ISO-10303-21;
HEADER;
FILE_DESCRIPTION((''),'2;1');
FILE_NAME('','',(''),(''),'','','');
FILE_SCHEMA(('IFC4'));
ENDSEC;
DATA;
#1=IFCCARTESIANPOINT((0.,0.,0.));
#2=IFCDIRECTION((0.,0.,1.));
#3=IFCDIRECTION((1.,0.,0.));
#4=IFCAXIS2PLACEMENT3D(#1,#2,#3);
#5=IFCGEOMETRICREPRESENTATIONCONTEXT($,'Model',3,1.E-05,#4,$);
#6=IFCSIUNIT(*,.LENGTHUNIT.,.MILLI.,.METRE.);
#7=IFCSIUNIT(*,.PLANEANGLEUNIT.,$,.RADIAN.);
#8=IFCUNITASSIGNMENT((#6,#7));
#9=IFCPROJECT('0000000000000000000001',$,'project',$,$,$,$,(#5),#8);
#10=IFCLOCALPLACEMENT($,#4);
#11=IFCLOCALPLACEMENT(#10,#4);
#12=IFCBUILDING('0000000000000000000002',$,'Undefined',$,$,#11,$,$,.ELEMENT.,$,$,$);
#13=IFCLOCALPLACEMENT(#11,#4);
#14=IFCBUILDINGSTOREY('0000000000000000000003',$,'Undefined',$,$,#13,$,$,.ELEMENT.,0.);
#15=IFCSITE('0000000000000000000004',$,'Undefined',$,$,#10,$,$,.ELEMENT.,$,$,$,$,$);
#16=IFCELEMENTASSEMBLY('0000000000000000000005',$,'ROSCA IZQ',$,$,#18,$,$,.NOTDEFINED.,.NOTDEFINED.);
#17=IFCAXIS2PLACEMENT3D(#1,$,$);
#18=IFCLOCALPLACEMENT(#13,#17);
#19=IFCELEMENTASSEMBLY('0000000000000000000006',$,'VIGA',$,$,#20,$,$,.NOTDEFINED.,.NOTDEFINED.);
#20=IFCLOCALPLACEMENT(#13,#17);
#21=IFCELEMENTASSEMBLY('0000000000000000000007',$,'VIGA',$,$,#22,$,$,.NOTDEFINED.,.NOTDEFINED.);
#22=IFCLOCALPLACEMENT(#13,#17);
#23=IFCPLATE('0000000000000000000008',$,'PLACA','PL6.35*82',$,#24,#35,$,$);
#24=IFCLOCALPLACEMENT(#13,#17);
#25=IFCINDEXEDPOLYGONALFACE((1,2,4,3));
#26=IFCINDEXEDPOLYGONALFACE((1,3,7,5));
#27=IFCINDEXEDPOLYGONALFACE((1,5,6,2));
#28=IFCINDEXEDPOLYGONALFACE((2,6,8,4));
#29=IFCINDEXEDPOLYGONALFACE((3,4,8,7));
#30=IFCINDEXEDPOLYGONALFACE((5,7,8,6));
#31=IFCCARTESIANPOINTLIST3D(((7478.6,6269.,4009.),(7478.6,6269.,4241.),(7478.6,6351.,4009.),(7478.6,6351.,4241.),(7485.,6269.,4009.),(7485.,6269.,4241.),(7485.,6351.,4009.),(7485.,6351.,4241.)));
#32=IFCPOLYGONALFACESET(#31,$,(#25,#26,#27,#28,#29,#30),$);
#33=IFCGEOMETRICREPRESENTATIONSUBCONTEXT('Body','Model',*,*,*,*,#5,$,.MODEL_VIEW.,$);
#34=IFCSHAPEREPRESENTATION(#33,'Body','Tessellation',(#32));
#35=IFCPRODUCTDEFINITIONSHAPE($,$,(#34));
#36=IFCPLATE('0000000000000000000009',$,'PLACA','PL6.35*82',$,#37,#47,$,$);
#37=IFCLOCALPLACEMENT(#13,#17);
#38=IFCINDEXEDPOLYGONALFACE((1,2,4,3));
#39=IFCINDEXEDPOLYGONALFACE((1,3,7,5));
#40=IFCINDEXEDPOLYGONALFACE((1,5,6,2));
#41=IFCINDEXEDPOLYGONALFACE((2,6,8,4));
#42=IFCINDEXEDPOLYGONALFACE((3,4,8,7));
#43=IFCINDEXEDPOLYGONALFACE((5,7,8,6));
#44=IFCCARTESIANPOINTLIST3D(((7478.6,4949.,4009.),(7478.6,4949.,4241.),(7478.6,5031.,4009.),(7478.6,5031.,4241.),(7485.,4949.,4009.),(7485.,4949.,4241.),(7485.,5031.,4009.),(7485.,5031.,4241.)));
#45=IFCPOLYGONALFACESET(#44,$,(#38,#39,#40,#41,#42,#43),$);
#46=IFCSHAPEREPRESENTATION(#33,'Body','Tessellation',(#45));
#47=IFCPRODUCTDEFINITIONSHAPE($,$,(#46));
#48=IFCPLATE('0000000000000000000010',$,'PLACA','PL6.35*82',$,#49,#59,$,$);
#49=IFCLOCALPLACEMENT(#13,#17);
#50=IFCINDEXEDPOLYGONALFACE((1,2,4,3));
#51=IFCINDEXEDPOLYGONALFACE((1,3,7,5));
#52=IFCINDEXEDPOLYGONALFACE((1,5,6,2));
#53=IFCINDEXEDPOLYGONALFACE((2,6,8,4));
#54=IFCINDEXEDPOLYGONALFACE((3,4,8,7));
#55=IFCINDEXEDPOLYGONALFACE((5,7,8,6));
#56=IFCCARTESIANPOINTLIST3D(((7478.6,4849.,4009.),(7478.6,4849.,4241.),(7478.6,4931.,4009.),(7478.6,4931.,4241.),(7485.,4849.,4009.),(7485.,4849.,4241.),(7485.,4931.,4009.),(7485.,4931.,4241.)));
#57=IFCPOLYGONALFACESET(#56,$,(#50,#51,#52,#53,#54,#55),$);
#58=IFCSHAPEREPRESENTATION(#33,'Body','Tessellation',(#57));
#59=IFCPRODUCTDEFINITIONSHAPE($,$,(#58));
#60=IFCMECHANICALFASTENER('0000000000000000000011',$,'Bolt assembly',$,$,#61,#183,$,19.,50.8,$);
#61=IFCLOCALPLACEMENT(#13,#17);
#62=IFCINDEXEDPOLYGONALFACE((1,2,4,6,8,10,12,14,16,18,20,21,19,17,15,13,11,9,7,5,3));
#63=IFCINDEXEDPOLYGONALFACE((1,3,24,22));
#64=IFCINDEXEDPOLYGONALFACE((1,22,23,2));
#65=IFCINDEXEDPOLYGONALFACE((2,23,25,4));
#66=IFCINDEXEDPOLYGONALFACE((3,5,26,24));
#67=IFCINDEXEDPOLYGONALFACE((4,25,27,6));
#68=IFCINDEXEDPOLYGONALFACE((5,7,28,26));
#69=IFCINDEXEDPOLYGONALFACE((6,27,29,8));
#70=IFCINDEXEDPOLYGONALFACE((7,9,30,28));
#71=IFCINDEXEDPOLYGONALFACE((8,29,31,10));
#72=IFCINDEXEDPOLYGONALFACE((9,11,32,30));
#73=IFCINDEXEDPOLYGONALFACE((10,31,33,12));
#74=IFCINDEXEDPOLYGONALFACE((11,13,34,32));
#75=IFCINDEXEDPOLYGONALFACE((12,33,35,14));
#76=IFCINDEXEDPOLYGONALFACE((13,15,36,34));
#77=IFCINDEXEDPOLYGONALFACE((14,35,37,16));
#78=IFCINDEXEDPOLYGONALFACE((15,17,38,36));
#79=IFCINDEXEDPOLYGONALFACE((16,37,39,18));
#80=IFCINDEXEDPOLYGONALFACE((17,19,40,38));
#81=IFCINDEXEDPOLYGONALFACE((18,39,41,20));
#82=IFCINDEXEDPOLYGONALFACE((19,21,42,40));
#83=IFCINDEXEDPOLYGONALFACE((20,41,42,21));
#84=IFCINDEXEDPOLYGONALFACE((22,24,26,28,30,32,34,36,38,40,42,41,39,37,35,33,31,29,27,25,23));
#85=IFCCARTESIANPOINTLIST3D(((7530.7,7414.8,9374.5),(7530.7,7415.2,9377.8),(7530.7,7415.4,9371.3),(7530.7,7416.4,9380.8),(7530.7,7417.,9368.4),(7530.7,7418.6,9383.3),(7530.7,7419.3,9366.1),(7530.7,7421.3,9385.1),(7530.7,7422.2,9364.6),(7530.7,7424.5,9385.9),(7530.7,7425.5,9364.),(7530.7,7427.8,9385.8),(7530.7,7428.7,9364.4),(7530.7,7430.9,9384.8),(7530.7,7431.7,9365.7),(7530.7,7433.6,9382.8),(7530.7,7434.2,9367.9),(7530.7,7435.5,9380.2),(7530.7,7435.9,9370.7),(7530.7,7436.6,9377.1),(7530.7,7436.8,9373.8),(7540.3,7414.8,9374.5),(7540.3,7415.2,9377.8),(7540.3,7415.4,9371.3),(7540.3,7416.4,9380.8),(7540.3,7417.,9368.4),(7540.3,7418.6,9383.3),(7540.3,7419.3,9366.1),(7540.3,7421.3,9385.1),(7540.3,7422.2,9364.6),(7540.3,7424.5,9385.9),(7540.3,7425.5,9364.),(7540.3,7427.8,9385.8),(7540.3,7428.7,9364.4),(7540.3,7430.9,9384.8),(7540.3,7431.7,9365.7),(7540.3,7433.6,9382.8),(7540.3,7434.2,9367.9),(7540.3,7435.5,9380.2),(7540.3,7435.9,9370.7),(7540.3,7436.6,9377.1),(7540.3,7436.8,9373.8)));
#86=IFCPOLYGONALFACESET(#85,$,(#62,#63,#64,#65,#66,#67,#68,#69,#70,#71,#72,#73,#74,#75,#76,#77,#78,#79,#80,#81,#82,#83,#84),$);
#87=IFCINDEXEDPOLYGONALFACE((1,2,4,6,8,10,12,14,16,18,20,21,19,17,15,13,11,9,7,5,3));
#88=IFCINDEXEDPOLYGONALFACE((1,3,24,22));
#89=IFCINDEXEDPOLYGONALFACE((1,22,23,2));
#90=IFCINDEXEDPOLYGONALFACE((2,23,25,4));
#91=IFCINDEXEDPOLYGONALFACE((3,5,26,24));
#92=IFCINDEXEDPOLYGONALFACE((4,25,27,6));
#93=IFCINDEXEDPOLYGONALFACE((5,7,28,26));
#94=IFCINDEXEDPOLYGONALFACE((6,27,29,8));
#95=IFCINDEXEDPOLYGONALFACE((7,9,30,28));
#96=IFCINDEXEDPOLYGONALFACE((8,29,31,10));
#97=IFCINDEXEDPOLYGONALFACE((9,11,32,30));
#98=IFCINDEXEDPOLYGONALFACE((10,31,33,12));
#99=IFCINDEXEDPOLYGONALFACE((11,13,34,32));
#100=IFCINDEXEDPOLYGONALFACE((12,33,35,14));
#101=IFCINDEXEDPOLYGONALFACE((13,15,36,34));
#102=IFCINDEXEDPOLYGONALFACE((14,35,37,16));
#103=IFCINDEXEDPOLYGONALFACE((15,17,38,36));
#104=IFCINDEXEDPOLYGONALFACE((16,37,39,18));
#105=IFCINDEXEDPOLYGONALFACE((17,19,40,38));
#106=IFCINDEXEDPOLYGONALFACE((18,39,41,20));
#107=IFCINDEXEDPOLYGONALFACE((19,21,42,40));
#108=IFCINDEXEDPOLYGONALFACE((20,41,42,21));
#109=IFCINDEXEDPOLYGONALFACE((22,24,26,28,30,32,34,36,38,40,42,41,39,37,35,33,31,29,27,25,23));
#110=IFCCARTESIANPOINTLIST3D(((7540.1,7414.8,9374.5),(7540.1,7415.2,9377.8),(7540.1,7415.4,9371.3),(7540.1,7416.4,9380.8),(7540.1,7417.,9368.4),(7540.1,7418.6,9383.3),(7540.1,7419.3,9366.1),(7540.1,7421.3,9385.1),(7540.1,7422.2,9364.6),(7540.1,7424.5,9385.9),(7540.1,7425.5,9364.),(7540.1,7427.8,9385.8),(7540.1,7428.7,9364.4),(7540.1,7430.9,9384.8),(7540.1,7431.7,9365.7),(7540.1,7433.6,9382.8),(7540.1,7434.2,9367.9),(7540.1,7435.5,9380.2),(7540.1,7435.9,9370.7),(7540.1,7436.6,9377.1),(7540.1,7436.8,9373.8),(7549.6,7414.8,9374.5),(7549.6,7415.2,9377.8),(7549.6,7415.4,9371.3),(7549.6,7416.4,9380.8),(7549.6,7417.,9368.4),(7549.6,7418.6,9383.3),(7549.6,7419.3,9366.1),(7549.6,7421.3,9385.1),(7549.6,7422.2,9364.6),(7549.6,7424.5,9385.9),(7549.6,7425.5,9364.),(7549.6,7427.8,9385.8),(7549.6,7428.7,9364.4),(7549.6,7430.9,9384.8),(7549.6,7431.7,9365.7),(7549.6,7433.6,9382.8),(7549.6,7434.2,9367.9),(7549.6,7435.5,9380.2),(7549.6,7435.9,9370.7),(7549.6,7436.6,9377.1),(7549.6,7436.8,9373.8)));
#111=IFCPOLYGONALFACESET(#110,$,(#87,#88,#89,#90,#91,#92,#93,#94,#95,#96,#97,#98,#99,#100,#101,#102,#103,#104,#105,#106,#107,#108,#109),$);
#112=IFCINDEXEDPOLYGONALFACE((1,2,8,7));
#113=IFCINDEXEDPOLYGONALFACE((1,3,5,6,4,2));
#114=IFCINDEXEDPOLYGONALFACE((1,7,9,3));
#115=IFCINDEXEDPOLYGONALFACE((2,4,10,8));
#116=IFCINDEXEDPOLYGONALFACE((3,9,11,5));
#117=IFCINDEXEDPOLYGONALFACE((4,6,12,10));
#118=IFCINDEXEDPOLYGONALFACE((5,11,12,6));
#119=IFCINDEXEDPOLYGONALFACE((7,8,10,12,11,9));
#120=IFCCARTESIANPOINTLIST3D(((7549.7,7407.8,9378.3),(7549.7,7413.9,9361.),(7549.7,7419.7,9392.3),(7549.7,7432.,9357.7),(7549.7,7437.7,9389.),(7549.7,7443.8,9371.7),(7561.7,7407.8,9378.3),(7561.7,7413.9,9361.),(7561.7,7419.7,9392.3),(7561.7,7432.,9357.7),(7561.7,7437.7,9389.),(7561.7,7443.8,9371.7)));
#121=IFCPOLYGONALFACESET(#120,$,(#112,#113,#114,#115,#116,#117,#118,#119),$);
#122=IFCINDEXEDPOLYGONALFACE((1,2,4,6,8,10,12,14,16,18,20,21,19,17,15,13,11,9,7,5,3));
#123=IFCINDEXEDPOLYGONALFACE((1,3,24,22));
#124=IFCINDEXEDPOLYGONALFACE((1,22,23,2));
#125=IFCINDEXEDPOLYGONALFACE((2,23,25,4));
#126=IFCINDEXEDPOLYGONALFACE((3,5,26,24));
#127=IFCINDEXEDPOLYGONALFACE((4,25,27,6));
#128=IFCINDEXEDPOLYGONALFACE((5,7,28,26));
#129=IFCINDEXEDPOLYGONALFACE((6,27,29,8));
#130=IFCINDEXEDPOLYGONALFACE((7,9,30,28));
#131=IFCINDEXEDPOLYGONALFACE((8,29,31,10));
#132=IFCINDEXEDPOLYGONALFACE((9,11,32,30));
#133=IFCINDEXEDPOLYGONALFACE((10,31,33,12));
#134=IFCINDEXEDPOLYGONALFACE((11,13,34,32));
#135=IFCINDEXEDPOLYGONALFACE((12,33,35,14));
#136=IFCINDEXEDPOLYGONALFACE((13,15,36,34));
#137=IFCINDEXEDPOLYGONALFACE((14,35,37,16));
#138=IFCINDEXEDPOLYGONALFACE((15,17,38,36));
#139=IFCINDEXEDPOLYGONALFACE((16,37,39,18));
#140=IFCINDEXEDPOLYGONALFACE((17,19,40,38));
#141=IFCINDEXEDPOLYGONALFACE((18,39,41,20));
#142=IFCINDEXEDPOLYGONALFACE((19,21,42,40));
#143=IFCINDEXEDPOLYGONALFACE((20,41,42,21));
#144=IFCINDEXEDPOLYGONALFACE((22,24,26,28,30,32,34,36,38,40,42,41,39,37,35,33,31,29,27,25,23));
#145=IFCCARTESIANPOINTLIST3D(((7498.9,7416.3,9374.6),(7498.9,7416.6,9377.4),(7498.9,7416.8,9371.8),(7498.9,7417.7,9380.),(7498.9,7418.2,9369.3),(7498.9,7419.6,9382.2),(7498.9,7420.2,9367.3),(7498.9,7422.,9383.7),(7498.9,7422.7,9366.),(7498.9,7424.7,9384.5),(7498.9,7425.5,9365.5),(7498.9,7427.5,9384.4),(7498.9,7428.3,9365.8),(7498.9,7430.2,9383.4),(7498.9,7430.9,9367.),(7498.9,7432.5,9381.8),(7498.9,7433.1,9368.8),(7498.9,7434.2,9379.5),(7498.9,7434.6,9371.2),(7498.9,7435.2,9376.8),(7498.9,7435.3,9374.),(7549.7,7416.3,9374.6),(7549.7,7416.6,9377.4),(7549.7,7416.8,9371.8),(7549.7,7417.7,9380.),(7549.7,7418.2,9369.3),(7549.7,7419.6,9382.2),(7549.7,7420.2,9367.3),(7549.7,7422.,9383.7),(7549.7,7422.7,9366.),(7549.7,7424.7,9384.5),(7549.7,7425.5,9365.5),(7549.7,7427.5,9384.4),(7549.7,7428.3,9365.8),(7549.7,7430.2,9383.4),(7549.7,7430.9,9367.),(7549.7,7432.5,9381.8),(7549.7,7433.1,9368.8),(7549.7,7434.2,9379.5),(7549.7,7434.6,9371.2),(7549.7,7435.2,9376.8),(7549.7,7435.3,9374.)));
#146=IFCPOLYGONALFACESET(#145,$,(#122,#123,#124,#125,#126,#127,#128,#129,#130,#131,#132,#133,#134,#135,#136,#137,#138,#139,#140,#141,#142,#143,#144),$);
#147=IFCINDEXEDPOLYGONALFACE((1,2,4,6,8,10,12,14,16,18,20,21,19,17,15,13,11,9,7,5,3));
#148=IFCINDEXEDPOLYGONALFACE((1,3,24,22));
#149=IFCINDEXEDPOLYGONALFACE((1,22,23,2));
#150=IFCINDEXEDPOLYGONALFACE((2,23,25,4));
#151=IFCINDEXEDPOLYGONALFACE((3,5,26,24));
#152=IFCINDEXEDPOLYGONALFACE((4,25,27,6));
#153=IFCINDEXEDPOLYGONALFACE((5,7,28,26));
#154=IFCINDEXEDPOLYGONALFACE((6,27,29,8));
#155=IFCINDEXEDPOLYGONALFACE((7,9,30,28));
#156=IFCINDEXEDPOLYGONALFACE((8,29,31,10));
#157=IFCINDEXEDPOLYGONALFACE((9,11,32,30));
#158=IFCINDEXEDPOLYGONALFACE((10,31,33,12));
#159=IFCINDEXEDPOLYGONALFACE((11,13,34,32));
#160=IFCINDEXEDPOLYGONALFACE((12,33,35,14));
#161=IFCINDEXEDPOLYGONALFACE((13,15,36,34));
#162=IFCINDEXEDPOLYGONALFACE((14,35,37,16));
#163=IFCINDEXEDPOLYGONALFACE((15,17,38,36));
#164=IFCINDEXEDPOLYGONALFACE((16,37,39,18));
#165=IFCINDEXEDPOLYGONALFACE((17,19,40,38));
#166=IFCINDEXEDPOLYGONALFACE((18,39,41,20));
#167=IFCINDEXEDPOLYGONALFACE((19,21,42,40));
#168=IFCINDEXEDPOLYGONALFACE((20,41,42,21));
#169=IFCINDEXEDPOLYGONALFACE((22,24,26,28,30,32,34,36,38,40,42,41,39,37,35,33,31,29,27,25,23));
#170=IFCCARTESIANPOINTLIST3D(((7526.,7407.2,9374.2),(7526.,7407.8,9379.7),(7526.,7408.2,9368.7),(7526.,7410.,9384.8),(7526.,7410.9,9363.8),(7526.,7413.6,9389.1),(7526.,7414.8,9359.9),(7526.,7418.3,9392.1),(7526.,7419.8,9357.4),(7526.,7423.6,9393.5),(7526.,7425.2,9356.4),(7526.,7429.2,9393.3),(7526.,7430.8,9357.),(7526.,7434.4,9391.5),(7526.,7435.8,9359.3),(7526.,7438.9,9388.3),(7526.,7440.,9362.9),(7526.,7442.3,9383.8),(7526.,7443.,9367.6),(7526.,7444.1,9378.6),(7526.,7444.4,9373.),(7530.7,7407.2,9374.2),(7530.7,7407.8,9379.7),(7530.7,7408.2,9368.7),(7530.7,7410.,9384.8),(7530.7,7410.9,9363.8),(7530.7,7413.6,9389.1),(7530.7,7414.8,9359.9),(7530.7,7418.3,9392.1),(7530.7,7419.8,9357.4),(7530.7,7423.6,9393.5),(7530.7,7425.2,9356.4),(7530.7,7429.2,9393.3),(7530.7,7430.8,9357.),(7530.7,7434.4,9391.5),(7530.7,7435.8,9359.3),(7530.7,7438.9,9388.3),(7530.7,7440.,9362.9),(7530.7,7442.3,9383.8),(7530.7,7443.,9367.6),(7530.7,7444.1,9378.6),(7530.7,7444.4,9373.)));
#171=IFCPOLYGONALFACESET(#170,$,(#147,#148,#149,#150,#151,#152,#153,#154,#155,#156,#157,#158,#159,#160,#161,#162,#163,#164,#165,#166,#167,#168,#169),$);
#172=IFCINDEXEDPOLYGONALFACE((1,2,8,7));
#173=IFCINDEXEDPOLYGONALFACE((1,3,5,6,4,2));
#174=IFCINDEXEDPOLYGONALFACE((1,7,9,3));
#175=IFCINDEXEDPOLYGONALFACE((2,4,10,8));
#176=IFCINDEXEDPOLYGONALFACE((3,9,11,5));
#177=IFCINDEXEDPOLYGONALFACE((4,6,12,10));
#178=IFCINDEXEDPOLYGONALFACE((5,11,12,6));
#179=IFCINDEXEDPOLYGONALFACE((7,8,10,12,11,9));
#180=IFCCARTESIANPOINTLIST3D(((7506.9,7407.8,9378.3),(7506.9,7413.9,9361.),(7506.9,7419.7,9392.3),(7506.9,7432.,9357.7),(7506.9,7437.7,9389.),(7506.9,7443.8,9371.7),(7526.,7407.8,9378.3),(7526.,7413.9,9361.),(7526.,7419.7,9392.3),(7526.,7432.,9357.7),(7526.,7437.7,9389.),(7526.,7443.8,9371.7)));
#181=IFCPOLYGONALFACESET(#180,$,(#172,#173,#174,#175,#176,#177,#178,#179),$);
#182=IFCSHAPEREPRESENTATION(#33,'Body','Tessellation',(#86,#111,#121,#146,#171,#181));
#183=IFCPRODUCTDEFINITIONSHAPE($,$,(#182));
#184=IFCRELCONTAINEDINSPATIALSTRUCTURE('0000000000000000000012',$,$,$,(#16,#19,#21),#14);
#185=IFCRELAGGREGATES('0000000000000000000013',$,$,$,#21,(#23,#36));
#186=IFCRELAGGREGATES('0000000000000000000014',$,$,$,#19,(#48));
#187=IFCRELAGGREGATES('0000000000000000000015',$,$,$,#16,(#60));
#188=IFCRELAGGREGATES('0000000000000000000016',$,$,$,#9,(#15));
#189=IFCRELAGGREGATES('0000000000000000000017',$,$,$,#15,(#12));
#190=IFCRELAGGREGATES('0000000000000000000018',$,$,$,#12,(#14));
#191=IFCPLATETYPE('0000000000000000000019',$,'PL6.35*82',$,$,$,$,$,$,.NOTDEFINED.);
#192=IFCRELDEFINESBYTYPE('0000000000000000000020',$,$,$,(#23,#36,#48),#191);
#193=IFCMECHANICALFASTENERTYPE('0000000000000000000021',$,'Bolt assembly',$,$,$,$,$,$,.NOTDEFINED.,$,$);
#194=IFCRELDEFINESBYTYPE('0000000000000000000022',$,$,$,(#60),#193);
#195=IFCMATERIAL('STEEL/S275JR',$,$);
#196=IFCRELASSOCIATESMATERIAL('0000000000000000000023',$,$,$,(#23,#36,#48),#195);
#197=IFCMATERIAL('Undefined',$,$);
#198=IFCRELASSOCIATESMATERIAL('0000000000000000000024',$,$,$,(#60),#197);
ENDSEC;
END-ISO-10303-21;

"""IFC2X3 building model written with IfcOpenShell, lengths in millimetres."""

from ifc_helpers import new_model, si_unit, frame, origin_with_axes, origin_2d_with_axis, place, context, subcontext, project, spatial, polyline, circle, outline, extrude, source, transform, mapped, material, type_object, element, aggregate, save


model = new_model("IFC2X3")

# Units and contexts
model_context = context("Model", 3, precision=1e-05, world=origin_with_axes())
body_context = subcontext(model_context, "Body", "Model", "MODEL_VIEW")
ifc_project = project(units=[si_unit("LENGTHUNIT", "METRE", prefix="MILLI"), si_unit("PLANEANGLEUNIT", "RADIAN")], contexts=[model_context])

# Site, building, storey
site_placement = place(None, origin_with_axes())
site = spatial("IfcSite", under=ifc_project, at=site_placement, Name="Undefined", CompositionType="ELEMENT")
building_placement = place(site_placement, origin_with_axes())
building = spatial("IfcBuilding", under=site, at=building_placement, Name="Undefined", CompositionType="ELEMENT")
storey_placement = place(building_placement, origin_with_axes())
storey = spatial("IfcBuildingStorey", under=building, at=storey_placement, Name="Undefined", CompositionType="ELEMENT", Elevation=0.0)

# Shared definitions
ifc_material_1 = material(Name="STEEL/S275JR")

# Element assembly
assembly_1_placement = place(storey_placement, origin_with_axes())
assembly_1 = element("IfcElementAssembly", 1, at=assembly_1_placement, inside=storey, Name="ROSCA IZQ", AssemblyPlace="NOTDEFINED", PredefinedType="NOTDEFINED")

# Element assembly
assembly_2_placement = place(storey_placement, origin_with_axes())
assembly_2 = element("IfcElementAssembly", 2, at=assembly_2_placement, inside=storey, Name="VIGA", AssemblyPlace="NOTDEFINED", PredefinedType="NOTDEFINED")

# Shared definitions
plate_type_1 = type_object("IfcPlateType", Name="PL6.35*82", PredefinedType="NOTDEFINED")

# Element assembly, plates
assembly_3_placement = place(storey_placement, origin_with_axes())
assembly_3 = element("IfcElementAssembly", 3, at=assembly_3_placement, inside=storey, Name="VIGA", AssemblyPlace="NOTDEFINED", PredefinedType="NOTDEFINED")
plate_1_placement = place(assembly_3_placement, frame((7481.8, 6269.0, 4241.0), z_axis=(-1.0, 0.0, 0.0), x_axis=(0.0, 1.0, 0.0)))
plate_1 = element("IfcPlate", 4, at=plate_1_placement, type_object=plate_type_1, material=ifc_material_1, Name="PLACA", Description="PL6.35*82", context=body_context, shape_type="SweptSolid", body=[
    extrude(outline(polyline([(0.0, 0.0), (82.0, 0.0), (82.0, 232.0), (0.0, 232.0), (0.0, 0.0)])), frame((0.0, 0.0, -3.2), z_axis=(0.0, 0.0, 1.0), x_axis=(1.0, 0.0, 0.0)), (0.0, 0.0, 1.0), 6.4),
])
plate_2_placement = place(assembly_3_placement, frame((7481.8, 4949.0, 4241.0), z_axis=(-1.0, 0.0, 0.0), x_axis=(0.0, 1.0, 0.0)))
plate_2 = element("IfcPlate", 5, at=plate_2_placement, type_object=plate_type_1, material=ifc_material_1, Name="PLACA", Description="PL6.35*82", context=body_context, shape_type="SweptSolid", body=[
    extrude(outline(polyline([(0.0, 0.0), (82.0, 0.0), (82.0, 232.0), (0.0, 232.0), (0.0, 0.0)])), frame((0.0, 0.0, -3.2), z_axis=(0.0, 0.0, 1.0), x_axis=(1.0, 0.0, 0.0)), (0.0, 0.0, 1.0), 6.4),
])
aggregate(assembly_3, [plate_1, plate_2])

# Plate
plate_3_placement = place(assembly_2_placement, frame((7481.8, 4849.0, 4241.0), z_axis=(-1.0, 0.0, 0.0), x_axis=(0.0, 1.0, 0.0)))
plate_3 = element("IfcPlate", 6, at=plate_3_placement, type_object=plate_type_1, material=ifc_material_1, Name="PLACA", Description="PL6.35*82", context=body_context, shape_type="SweptSolid", body=[
    extrude(outline(polyline([(0.0, 0.0), (82.0, 0.0), (82.0, 232.0), (0.0, 232.0), (0.0, 0.0)])), frame((0.0, 0.0, -3.2), z_axis=(0.0, 0.0, 1.0), x_axis=(1.0, 0.0, 0.0)), (0.0, 0.0, 1.0), 6.4),
])
aggregate(assembly_2, [plate_3])

# Mechanical fastener
ifc_material_2 = material(Name="Undefined")
mechanical_fastener_type = type_object("IfcMechanicalFastenerType", Name="Bolt assembly")
shared_shape_1 = source(origin_with_axes(), body_context, "Body", "SweptSolid", [
    extrude(circle(Radius=11.0, at=origin_2d_with_axis()), frame((0.0, 4.6, 0.0), z_axis=(0.0, 1.0, 0.0), x_axis=(1.0, 0.0, 0.0)), (0.0, 0.0, 1.0), 9.6),
    extrude(circle(Radius=11.0, at=origin_2d_with_axis()), frame((0.0, -4.6, 0.0), z_axis=(0.0, 1.0, 0.0), x_axis=(1.0, 0.0, 0.0)), (0.0, 0.0, 1.0), 9.5),
    extrude(outline(polyline([(15.9, -9.2), (15.9, 9.2), (0.0, 18.3), (-15.9, 9.2), (-15.9, -9.2), (0.0, -18.3), (15.9, -9.2)])), frame((0.0, -16.7, 0.0), z_axis=(0.0, 1.0, 0.0), x_axis=(1.0, 0.0, 0.0)), (0.0, 0.0, 1.0), 11.9),
    extrude(circle(Radius=9.5, at=origin_2d_with_axis()), frame((0.0, -4.7, 0.0), z_axis=(0.0, 1.0, 0.0), x_axis=(1.0, 0.0, 0.0)), (0.0, 0.0, 1.0), 50.8),
    extrude(circle(Radius=18.7, at=origin_2d_with_axis()), frame((0.0, 14.2, 0.0), z_axis=(0.0, 1.0, 0.0), x_axis=(1.0, 0.0, 0.0)), (0.0, 0.0, 1.0), 4.8),
    extrude(outline(polyline([(15.9, -9.2), (15.9, 9.2), (0.0, 18.3), (-15.9, 9.2), (-15.9, -9.2), (0.0, -18.3), (15.9, -9.2)])), frame((0.0, 19.0, 0.0), z_axis=(0.0, 1.0, 0.0), x_axis=(1.0, 0.0, 0.0)), (0.0, 0.0, 1.0), 19.1),
])
mechanical_fastener_1_placement = place(assembly_1_placement, frame((7545.0, 7425.8, 9375.0), z_axis=(0.0, 0.335983, -0.941868), x_axis=(0.0, -0.941868, -0.335983)))
mechanical_fastener_1 = element("IfcMechanicalFastener", 7, at=mechanical_fastener_1_placement, type_object=mechanical_fastener_type, material=ifc_material_2, Name="Bolt assembly", NominalDiameter=19.0, NominalLength=50.8, context=body_context, shape_type="MappedRepresentation", body=[
    mapped(shared_shape_1, transform((0.0, 0.0, 0.0))),
])
aggregate(assembly_1, [mechanical_fastener_1])

save(model, "model.ifc")
